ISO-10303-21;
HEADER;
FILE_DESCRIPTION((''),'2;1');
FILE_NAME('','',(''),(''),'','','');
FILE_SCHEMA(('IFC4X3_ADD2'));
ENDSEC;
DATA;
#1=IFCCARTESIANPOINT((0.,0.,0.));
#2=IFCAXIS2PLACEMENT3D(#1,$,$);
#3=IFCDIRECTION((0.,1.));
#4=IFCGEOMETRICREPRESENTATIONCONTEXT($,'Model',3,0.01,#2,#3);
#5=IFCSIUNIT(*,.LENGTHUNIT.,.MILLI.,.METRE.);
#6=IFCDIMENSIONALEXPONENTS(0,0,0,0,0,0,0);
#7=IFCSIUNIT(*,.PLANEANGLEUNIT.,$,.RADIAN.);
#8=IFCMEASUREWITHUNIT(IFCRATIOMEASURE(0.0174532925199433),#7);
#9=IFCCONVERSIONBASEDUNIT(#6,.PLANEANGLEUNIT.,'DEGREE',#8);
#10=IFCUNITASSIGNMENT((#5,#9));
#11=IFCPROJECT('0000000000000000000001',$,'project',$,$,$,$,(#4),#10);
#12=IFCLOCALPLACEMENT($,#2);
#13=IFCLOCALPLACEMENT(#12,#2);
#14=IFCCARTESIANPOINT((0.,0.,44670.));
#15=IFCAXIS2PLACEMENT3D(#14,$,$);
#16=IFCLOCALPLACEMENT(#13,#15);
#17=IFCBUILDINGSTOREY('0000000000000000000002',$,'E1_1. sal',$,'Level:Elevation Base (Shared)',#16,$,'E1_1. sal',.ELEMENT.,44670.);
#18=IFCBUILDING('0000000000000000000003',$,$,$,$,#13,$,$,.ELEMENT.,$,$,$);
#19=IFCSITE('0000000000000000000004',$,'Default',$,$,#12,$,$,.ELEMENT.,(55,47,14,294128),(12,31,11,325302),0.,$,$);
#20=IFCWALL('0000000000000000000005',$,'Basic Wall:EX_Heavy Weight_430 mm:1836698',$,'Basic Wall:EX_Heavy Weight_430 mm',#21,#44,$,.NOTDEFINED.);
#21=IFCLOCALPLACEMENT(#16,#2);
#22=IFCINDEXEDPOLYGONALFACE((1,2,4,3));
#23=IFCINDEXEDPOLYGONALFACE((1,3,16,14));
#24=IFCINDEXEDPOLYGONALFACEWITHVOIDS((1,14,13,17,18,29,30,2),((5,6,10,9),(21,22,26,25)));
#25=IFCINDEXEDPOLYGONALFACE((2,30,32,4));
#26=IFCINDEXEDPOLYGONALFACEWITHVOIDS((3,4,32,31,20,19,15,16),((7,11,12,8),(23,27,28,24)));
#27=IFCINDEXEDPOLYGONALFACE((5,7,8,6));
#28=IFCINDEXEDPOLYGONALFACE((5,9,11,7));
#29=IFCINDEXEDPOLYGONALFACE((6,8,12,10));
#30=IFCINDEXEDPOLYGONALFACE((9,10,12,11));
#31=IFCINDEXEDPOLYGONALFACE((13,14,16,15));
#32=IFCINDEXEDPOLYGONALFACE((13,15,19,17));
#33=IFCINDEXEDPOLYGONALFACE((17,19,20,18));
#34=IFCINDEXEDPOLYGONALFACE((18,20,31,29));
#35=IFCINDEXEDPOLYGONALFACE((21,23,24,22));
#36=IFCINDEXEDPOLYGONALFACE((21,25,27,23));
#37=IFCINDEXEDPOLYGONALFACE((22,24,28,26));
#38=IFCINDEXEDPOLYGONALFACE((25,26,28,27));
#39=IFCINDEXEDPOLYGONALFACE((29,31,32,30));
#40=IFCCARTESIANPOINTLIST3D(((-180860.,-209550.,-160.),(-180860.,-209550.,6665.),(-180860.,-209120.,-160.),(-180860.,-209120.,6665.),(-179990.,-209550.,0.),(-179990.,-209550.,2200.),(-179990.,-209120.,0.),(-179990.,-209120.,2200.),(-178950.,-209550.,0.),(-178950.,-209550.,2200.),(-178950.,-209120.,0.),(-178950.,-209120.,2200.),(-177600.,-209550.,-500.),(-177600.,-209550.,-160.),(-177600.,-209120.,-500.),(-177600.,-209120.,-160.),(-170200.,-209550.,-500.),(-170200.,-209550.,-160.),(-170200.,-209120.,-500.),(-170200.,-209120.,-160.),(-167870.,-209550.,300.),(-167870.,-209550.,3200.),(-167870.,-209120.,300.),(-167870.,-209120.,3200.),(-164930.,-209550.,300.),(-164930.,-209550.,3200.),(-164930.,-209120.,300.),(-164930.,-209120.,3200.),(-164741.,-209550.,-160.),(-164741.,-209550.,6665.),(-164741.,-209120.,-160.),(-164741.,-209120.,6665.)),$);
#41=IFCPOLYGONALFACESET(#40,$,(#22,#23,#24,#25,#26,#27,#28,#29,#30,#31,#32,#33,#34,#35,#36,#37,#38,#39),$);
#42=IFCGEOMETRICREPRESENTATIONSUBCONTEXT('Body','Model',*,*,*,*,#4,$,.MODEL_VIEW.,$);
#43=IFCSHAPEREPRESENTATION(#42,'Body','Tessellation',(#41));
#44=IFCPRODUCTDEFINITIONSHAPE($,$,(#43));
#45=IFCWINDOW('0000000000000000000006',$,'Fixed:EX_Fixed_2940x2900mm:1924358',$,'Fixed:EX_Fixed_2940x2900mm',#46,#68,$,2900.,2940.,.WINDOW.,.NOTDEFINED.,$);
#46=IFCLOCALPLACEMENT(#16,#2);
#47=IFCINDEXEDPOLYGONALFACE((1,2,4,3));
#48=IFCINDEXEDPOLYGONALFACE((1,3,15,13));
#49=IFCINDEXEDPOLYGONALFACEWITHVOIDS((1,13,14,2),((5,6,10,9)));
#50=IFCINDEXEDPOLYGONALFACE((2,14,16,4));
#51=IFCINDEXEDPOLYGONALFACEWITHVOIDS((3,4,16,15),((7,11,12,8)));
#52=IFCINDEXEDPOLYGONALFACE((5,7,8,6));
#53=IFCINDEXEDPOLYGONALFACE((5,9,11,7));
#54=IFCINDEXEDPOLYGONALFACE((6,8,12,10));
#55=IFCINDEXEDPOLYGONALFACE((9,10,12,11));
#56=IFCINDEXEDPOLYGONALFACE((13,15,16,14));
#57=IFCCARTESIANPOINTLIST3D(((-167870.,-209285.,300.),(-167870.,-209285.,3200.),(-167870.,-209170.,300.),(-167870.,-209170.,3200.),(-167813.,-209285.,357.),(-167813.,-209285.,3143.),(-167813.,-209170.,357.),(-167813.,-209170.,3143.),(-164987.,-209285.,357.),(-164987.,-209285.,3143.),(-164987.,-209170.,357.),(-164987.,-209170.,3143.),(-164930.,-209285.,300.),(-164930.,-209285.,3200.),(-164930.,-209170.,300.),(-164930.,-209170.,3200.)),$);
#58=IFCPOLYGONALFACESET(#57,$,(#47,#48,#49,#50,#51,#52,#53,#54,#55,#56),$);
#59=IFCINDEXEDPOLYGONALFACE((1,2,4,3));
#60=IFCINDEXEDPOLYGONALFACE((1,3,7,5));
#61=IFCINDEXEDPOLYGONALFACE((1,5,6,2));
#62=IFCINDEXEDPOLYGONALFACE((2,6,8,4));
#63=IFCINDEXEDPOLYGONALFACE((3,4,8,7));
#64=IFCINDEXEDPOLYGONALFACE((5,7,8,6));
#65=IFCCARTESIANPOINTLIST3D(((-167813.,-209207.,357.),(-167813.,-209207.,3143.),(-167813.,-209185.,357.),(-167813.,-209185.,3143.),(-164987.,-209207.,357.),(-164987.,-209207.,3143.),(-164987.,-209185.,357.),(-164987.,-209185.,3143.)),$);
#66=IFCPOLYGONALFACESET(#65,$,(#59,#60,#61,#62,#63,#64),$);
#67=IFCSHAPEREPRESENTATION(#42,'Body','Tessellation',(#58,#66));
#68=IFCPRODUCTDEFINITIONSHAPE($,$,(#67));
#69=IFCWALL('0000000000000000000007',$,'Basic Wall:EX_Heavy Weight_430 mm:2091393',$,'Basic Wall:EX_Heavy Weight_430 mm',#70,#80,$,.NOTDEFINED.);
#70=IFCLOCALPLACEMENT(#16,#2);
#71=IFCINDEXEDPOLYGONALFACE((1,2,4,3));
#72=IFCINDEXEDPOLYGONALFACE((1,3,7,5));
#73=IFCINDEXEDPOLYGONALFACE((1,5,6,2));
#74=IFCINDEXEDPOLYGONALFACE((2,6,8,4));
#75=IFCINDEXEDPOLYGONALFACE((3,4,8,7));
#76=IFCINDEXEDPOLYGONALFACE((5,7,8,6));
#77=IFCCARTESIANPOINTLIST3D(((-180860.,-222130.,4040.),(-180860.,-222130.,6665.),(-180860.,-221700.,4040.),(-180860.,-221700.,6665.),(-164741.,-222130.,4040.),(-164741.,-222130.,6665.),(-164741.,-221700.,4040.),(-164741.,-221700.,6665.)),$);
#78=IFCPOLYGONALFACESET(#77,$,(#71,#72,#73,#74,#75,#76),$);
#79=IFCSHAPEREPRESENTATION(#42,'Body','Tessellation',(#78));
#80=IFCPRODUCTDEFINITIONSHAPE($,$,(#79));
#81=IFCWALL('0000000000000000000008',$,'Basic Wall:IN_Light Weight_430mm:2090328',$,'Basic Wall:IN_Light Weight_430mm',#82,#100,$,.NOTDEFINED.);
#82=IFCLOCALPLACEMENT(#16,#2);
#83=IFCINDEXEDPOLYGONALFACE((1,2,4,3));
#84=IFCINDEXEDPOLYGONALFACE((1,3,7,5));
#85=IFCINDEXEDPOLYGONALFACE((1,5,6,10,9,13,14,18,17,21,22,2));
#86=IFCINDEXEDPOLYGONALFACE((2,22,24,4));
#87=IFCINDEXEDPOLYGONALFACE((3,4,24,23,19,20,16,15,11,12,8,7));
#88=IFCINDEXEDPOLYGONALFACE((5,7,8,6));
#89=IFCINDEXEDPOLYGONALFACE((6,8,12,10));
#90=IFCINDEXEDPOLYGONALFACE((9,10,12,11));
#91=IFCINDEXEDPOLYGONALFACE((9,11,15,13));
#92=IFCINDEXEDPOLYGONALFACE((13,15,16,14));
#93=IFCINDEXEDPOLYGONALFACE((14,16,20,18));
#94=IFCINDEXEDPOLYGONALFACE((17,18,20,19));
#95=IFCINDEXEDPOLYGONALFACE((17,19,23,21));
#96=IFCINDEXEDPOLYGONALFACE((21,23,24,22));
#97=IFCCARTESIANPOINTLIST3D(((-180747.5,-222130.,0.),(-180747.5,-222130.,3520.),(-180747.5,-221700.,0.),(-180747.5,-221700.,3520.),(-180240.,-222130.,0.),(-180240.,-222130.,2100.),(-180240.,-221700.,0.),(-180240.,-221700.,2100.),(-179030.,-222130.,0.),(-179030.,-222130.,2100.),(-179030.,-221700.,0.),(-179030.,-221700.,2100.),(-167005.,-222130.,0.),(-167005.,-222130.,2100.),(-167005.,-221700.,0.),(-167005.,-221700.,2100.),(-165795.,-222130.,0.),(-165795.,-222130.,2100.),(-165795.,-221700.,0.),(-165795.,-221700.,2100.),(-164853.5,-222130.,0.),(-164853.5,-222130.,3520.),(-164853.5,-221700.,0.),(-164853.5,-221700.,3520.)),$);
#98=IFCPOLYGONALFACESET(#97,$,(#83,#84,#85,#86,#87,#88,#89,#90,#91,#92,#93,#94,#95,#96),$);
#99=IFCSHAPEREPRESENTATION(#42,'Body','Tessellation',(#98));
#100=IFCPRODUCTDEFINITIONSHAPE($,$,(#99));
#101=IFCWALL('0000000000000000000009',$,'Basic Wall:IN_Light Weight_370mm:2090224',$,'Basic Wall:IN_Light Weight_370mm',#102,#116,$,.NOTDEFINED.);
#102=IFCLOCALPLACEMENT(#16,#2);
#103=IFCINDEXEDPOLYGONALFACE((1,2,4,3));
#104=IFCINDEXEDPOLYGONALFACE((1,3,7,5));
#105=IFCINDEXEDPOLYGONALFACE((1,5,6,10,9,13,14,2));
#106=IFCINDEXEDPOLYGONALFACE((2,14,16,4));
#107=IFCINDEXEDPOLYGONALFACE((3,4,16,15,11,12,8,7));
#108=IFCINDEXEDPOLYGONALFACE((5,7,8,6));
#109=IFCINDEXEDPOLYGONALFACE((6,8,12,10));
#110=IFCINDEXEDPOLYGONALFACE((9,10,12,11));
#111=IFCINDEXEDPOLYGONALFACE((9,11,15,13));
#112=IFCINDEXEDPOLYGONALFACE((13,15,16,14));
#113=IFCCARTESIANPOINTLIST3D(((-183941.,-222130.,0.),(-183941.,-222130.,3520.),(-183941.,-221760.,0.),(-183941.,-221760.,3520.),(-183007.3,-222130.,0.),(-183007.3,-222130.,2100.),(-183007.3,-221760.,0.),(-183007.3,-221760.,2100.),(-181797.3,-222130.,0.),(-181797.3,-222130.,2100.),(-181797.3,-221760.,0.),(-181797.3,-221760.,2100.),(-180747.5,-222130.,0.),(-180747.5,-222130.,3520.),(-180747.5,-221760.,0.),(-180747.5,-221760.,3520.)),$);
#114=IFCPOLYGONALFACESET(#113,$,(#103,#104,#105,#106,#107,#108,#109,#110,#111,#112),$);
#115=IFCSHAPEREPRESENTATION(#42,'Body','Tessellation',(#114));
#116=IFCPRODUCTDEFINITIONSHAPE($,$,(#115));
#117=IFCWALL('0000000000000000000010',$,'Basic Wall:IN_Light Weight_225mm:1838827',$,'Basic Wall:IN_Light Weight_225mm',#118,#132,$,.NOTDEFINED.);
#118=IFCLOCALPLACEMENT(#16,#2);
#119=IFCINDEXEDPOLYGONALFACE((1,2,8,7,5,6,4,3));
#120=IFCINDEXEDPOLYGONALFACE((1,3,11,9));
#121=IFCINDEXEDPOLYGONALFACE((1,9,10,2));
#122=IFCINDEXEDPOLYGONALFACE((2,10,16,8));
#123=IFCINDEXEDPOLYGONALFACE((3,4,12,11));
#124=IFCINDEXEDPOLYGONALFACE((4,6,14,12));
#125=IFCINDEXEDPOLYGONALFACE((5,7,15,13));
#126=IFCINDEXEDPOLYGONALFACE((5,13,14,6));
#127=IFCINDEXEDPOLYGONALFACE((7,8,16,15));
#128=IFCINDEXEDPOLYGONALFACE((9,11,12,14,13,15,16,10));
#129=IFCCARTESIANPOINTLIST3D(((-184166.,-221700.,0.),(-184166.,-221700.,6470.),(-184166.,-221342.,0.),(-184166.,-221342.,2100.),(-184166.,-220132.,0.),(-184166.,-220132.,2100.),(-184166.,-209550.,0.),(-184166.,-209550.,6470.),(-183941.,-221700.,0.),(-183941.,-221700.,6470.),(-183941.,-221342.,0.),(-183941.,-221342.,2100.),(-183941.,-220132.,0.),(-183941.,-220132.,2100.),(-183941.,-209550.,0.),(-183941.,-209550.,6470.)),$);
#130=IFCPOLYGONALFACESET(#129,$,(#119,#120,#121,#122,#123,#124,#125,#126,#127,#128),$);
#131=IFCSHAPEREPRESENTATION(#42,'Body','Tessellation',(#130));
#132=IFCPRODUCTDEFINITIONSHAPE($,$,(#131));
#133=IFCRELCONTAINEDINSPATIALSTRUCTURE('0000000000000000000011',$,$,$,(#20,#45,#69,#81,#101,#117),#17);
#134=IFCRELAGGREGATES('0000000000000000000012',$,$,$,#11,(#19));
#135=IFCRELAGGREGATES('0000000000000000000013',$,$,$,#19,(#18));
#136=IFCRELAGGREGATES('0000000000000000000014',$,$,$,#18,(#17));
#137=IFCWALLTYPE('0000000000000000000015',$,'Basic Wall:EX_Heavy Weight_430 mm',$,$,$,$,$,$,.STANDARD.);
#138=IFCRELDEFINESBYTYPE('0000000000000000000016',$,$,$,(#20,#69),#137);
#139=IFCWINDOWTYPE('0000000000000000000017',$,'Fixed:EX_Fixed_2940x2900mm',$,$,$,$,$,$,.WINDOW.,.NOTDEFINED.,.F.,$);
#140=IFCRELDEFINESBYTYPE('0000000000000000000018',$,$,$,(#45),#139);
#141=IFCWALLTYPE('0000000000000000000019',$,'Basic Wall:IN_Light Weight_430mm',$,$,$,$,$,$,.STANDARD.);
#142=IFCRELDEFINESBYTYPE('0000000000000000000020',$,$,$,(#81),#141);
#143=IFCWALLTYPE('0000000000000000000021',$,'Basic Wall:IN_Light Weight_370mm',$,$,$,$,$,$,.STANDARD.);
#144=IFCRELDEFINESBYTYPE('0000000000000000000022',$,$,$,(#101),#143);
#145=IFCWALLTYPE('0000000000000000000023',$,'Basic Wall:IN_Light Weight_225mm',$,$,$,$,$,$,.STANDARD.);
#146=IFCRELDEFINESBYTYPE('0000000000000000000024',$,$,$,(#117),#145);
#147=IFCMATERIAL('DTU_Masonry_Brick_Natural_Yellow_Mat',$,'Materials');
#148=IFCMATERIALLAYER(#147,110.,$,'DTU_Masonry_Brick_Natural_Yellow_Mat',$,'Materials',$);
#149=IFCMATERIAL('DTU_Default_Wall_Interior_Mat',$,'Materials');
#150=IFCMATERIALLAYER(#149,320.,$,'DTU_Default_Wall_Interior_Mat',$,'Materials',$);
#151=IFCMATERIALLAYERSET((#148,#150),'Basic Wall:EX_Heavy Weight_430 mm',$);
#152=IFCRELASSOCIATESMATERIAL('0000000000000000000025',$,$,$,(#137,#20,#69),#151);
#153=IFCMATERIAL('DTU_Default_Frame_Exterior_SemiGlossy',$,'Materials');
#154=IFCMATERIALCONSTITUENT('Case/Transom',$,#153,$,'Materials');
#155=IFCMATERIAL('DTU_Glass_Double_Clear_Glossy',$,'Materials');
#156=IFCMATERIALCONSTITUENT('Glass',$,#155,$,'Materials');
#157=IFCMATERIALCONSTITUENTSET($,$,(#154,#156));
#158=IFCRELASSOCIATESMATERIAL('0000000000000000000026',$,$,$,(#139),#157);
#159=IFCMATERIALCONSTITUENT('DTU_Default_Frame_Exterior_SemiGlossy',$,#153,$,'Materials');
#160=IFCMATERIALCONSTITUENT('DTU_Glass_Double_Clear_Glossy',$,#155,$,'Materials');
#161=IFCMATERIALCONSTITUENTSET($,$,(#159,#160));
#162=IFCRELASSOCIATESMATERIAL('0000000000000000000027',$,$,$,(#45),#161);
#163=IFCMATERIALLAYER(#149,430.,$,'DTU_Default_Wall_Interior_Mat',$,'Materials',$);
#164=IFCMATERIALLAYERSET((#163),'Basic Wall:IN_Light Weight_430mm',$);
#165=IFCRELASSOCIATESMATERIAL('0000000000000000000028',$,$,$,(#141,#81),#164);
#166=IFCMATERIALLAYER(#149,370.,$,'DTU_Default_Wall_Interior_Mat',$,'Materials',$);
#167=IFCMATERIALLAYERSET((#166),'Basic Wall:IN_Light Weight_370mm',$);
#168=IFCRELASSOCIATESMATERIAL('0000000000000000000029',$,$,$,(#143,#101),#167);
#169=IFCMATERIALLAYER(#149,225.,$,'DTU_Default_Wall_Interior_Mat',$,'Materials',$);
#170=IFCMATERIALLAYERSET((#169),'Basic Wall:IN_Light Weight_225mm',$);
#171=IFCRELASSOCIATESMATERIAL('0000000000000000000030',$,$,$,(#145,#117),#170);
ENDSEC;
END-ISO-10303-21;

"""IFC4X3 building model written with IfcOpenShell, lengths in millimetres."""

from ifc_helpers import new_model, entity, si_unit, converted_unit, direction, frame, frame_2d, origin, origin_2d_with_axis, place, context, subcontext, project, spatial, polyline, rectangle, outline, extrude, source, transform, mapped, material, layer, layer_set, constituent, constituent_set, type_object, type_shapes, element, fill, save


model = new_model("IFC4X3")

# Units and contexts
model_context = context("Model", 3, precision=0.01, world=origin(), true_north=direction((0.0, 1.0)))
body_context = subcontext(model_context, "Body", "Model", "MODEL_VIEW")
ifc_project = project(units=[si_unit("LENGTHUNIT", "METRE", prefix="MILLI"), converted_unit("PLANEANGLEUNIT", "DEGREE", entity("IfcRatioMeasure", 0.0174532925199433), si_unit("PLANEANGLEUNIT", "RADIAN"), dimensions=[0, 0, 0, 0, 0, 0, 0])], contexts=[model_context])

# Site, building, storey
site_placement = place(None, origin())
site = spatial("IfcSite", under=ifc_project, at=site_placement, Name="Default", CompositionType="ELEMENT", RefLatitude=(55, 47, 14, 294128), RefLongitude=(12, 31, 11, 325302), RefElevation=0.0)
building_placement = place(site_placement, origin())
building = spatial("IfcBuilding", under=site, at=building_placement, CompositionType="ELEMENT")
storey_placement = place(building_placement, frame((0.0, 0.0, 44670.0)))
storey = spatial("IfcBuildingStorey", under=building, at=storey_placement, Name="E1_1. sal", ObjectType="Level:Elevation Base (Shared)", LongName="E1_1. sal", CompositionType="ELEMENT", Elevation=44670.0)

# Shared definitions
ifc_material_1 = material(Name="DTU_Default_Wall_Interior_Mat", Category="Materials")

# Wall, openings, window
ifc_material_2 = material(Name="DTU_Masonry_Brick_Natural_Yellow_Mat", Category="Materials")
ifc_layer_1 = layer(ifc_material_2, 110.0, Name="DTU_Masonry_Brick_Natural_Yellow_Mat", Category="Materials")
ifc_layer_2 = layer(ifc_material_1, 320.0, Name="DTU_Default_Wall_Interior_Mat", Category="Materials")
ifc_layer_set_1 = layer_set([ifc_layer_1, ifc_layer_2], Name="Basic Wall:EX_Heavy Weight_430 mm")
wall_type_1 = type_object("IfcWallType", Name="Basic Wall:EX_Heavy Weight_430 mm", PredefinedType="STANDARD", material=ifc_layer_set_1)
wall_1_placement = place(storey_placement, frame((-180860.0, -209335.0, -500.0)))
wall_1 = element("IfcWall", 1, at=wall_1_placement, inside=storey, type_object=wall_type_1, material=ifc_layer_set_1, Name="Basic Wall:EX_Heavy Weight_430 mm:1836698", ObjectType="Basic Wall:EX_Heavy Weight_430 mm", PredefinedType="NOTDEFINED", context=body_context, shape_type="SweptSolid", body=[
    extrude(rectangle(XDim=16119.0, YDim=430.0, at=frame_2d((8059.5, 0.0), x_axis=(-1.0, 0.0))), origin(), (0.0, 0.0, 1.0), 7165.0),
])
opening_1_placement = place(wall_1_placement, origin())
element("IfcOpeningElement", 2, at=opening_1_placement, cuts=wall_1, PredefinedType="OPENING", context=body_context, shape_type="SweptSolid", body=[
    extrude(rectangle(XDim=340.0, YDim=5459.0, at=frame_2d((0.0, 0.0), x_axis=(0.0, 1.0))), frame((13389.5, 215.0, 170.0), z_axis=(0.0, -1.0, 0.0), x_axis=(1.0, 0.0, 0.0)), (0.0, 0.0, 1.0), 430.0),
])
opening_2_placement = place(wall_1_placement, origin())
element("IfcOpeningElement", 3, at=opening_2_placement, cuts=wall_1, PredefinedType="OPENING", context=body_context, shape_type="SweptSolid", body=[
    extrude(rectangle(XDim=340.0, YDim=3260.0, at=frame_2d((0.0, 0.0), x_axis=(1.0, 0.0))), frame((1630.0, 215.0, 170.0), z_axis=(0.0, -1.0, 0.0), x_axis=(0.0, 0.0, -1.0)), (0.0, 0.0, 1.0), 430.0),
])
opening_3_placement = place(wall_1_placement, frame((870.0, -215.0, 500.0)))
element("IfcOpeningElement", 4, at=opening_3_placement, cuts=wall_1, PredefinedType="OPENING", context=body_context, shape_type="SweptSolid", body=[
    extrude(rectangle(XDim=2200.0, YDim=1040.0, at=frame_2d((1100.0, 520.0), x_axis=(1.0, 0.0))), frame((0.0, 0.0, 0.0), z_axis=(0.0, 1.0, 0.0), x_axis=(0.0, 0.0, 1.0)), (0.0, 0.0, 1.0), 430.0),
])
opening_4_placement = place(wall_1_placement, frame((12990.0, -215.0, 800.0)))
opening_4 = element("IfcOpeningElement", 5, at=opening_4_placement, cuts=wall_1, PredefinedType="OPENING", context=body_context, shape_type="SweptSolid", body=[
    extrude(rectangle(XDim=2900.0, YDim=2940.0, at=frame_2d((1450.0, 1470.0), x_axis=(1.0, 0.0))), frame((0.0, 0.0, 0.0), z_axis=(0.0, 1.0, 0.0), x_axis=(0.0, 0.0, 1.0)), (0.0, 0.0, 1.0), 430.0),
])
ifc_material_3 = material(Name="DTU_Default_Frame_Exterior_SemiGlossy", Category="Materials")
ifc_constituent_1 = constituent(ifc_material_3, Name="DTU_Default_Frame_Exterior_SemiGlossy", Category="Materials")
ifc_material_4 = material(Name="DTU_Glass_Double_Clear_Glossy", Category="Materials")
ifc_constituent_2 = constituent(ifc_material_4, Name="DTU_Glass_Double_Clear_Glossy", Category="Materials")
ifc_constituent_set_1 = constituent_set(constituents=[ifc_constituent_1, ifc_constituent_2])
ifc_constituent_3 = constituent(ifc_material_3, Name="Case/Transom", Category="Materials")
ifc_constituent_4 = constituent(ifc_material_4, Name="Glass", Category="Materials")
ifc_constituent_set_2 = constituent_set(constituents=[ifc_constituent_3, ifc_constituent_4])
window_type = type_object("IfcWindowType", Name="Fixed:EX_Fixed_2940x2900mm", ParameterTakesPrecedence=False, PartitioningType="NOTDEFINED", PredefinedType="WINDOW", material=ifc_constituent_set_2)
shared_shape_1 = source(origin(), body_context, "Body", "SweptSolid", [
    extrude(outline(polyline([(-1470.0, -1450.0), (1470.0, -1450.0), (1470.0, 1450.0), (-1470.0, 1450.0), (-1470.0, -1450.0)]), holes=[polyline([(-1413.0, 1393.0), (1413.0, 1393.0), (1413.0, -1393.0), (-1413.0, -1393.0), (-1413.0, 1393.0)])]), frame((1470.0, 380.0, 1450.0), z_axis=(0.0, -1.0, 0.0), x_axis=(1.0, 0.0, 0.0)), (0.0, 0.0, 1.0), 115.0),
    extrude(rectangle(XDim=2826.0, YDim=22.0, at=origin_2d_with_axis()), frame((1470.0, 354.0, 57.0), z_axis=(0.0, 0.0, 1.0), x_axis=(-1.0, 0.0, 0.0)), (0.0, 0.0, 1.0), 2786.0),
])
type_shapes(window_type, [shared_shape_1])
window_placement = place(opening_4_placement, origin())
window = element("IfcWindow", 6, at=window_placement, inside=storey, type_object=window_type, material=ifc_constituent_set_1, Name="Fixed:EX_Fixed_2940x2900mm:1924358", ObjectType="Fixed:EX_Fixed_2940x2900mm", OverallHeight=2900.0, OverallWidth=2940.0, PartitioningType="NOTDEFINED", PredefinedType="WINDOW", context=body_context, shape_type="MappedRepresentation", body=[
    mapped(shared_shape_1, transform((0.0, 0.0, 0.0), scale=1.0)),
])
fill(opening_4, window)

# Wall
wall_2_placement = place(storey_placement, frame((-180860.0, -221915.0, 4040.0)))
element("IfcWall", 7, at=wall_2_placement, inside=storey, type_object=wall_type_1, material=ifc_layer_set_1, Name="Basic Wall:EX_Heavy Weight_430 mm:2091393", ObjectType="Basic Wall:EX_Heavy Weight_430 mm", PredefinedType="NOTDEFINED", context=body_context, shape_type="SweptSolid", body=[
    extrude(rectangle(XDim=16119.0, YDim=430.0, at=frame_2d((8059.5, 0.0), x_axis=(-1.0, 0.0))), origin(), (0.0, 0.0, 1.0), 2625.0),
])

# Wall, openings
ifc_layer_3 = layer(ifc_material_1, 430.0, Name="DTU_Default_Wall_Interior_Mat", Category="Materials")
ifc_layer_set_2 = layer_set([ifc_layer_3], Name="Basic Wall:IN_Light Weight_430mm")
wall_type_2 = type_object("IfcWallType", Name="Basic Wall:IN_Light Weight_430mm", PredefinedType="STANDARD", material=ifc_layer_set_2)
wall_3_placement = place(storey_placement, frame((-180747.5, -221915.0, 0.0)))
wall_3 = element("IfcWall", 8, at=wall_3_placement, inside=storey, type_object=wall_type_2, material=ifc_layer_set_2, Name="Basic Wall:IN_Light Weight_430mm:2090328", ObjectType="Basic Wall:IN_Light Weight_430mm", PredefinedType="NOTDEFINED", context=body_context, shape_type="SweptSolid", body=[
    extrude(rectangle(XDim=15894.0, YDim=430.0, at=frame_2d((7947.0, 0.0), x_axis=(1.0, 0.0))), origin(), (0.0, 0.0, 1.0), 3520.0),
])
opening_5_placement = place(wall_3_placement, frame((1717.5, 215.0, 0.0)))
element("IfcOpeningElement", 9, at=opening_5_placement, cuts=wall_3, PredefinedType="OPENING", context=body_context, shape_type="SweptSolid", body=[
    extrude(rectangle(XDim=2100.0, YDim=1210.0, at=frame_2d((1050.0, 605.0), x_axis=(1.0, 0.0))), frame((0.0, 0.0, 0.0), z_axis=(0.0, -1.0, 0.0), x_axis=(0.0, 0.0, 1.0)), (0.0, 0.0, 1.0), 430.0),
])
opening_6_placement = place(wall_3_placement, frame((14952.5, 215.0, 0.0)))
element("IfcOpeningElement", 10, at=opening_6_placement, cuts=wall_3, PredefinedType="OPENING", context=body_context, shape_type="SweptSolid", body=[
    extrude(rectangle(XDim=2100.0, YDim=1210.0, at=frame_2d((1050.0, 605.0), x_axis=(1.0, 0.0))), frame((0.0, 0.0, 0.0), z_axis=(0.0, -1.0, 0.0), x_axis=(0.0, 0.0, 1.0)), (0.0, 0.0, 1.0), 430.0),
])

# Walls, openings
ifc_layer_4 = layer(ifc_material_1, 370.0, Name="DTU_Default_Wall_Interior_Mat", Category="Materials")
ifc_layer_set_3 = layer_set([ifc_layer_4], Name="Basic Wall:IN_Light Weight_370mm")
wall_type_3 = type_object("IfcWallType", Name="Basic Wall:IN_Light Weight_370mm", PredefinedType="STANDARD", material=ifc_layer_set_3)
wall_4_placement = place(storey_placement, frame((-183941.0, -221945.0, 0.0)))
wall_4 = element("IfcWall", 11, at=wall_4_placement, inside=storey, type_object=wall_type_3, material=ifc_layer_set_3, Name="Basic Wall:IN_Light Weight_370mm:2090224", ObjectType="Basic Wall:IN_Light Weight_370mm", PredefinedType="NOTDEFINED", context=body_context, shape_type="SweptSolid", body=[
    extrude(rectangle(XDim=3193.5, YDim=370.0, at=frame_2d((1596.7, 0.0), x_axis=(-1.0, 0.0))), origin(), (0.0, 0.0, 1.0), 3520.0),
])
opening_7_placement = place(wall_4_placement, frame((2143.7, 185.0, 0.0)))
element("IfcOpeningElement", 12, at=opening_7_placement, cuts=wall_4, PredefinedType="OPENING", context=body_context, shape_type="SweptSolid", body=[
    extrude(rectangle(XDim=2100.0, YDim=1210.0, at=frame_2d((1050.0, 605.0), x_axis=(1.0, 0.0))), frame((0.0, 0.0, 0.0), z_axis=(0.0, -1.0, 0.0), x_axis=(0.0, 0.0, 1.0)), (0.0, 0.0, 1.0), 370.0),
])
ifc_layer_5 = layer(ifc_material_1, 225.0, Name="DTU_Default_Wall_Interior_Mat", Category="Materials")
ifc_layer_set_4 = layer_set([ifc_layer_5], Name="Basic Wall:IN_Light Weight_225mm")
wall_type_4 = type_object("IfcWallType", Name="Basic Wall:IN_Light Weight_225mm", PredefinedType="STANDARD", material=ifc_layer_set_4)
wall_5_placement = place(storey_placement, frame((-184053.5, -221700.0, 0.0), z_axis=(0.0, 0.0, 1.0), x_axis=(0.0, 1.0, 0.0)))
wall_5 = element("IfcWall", 13, at=wall_5_placement, inside=storey, type_object=wall_type_4, material=ifc_layer_set_4, Name="Basic Wall:IN_Light Weight_225mm:1838827", ObjectType="Basic Wall:IN_Light Weight_225mm", PredefinedType="NOTDEFINED", context=body_context, shape_type="SweptSolid", body=[
    extrude(rectangle(XDim=12150.0, YDim=225.0, at=frame_2d((6075.0, 0.0), x_axis=(1.0, 0.0))), origin(), (0.0, 0.0, 1.0), 6470.0),
])
opening_8_placement = place(wall_5_placement, frame((358.0, -112.5, 0.0)))
element("IfcOpeningElement", 14, at=opening_8_placement, cuts=wall_5, PredefinedType="OPENING", context=body_context, shape_type="SweptSolid", body=[
    extrude(rectangle(XDim=2100.0, YDim=1210.0, at=frame_2d((1050.0, 605.0), x_axis=(1.0, 0.0))), frame((0.0, 0.0, 0.0), z_axis=(0.0, 1.0, 0.0), x_axis=(0.0, 0.0, 1.0)), (0.0, 0.0, 1.0), 225.0),
])

save(model, "model.ifc")
